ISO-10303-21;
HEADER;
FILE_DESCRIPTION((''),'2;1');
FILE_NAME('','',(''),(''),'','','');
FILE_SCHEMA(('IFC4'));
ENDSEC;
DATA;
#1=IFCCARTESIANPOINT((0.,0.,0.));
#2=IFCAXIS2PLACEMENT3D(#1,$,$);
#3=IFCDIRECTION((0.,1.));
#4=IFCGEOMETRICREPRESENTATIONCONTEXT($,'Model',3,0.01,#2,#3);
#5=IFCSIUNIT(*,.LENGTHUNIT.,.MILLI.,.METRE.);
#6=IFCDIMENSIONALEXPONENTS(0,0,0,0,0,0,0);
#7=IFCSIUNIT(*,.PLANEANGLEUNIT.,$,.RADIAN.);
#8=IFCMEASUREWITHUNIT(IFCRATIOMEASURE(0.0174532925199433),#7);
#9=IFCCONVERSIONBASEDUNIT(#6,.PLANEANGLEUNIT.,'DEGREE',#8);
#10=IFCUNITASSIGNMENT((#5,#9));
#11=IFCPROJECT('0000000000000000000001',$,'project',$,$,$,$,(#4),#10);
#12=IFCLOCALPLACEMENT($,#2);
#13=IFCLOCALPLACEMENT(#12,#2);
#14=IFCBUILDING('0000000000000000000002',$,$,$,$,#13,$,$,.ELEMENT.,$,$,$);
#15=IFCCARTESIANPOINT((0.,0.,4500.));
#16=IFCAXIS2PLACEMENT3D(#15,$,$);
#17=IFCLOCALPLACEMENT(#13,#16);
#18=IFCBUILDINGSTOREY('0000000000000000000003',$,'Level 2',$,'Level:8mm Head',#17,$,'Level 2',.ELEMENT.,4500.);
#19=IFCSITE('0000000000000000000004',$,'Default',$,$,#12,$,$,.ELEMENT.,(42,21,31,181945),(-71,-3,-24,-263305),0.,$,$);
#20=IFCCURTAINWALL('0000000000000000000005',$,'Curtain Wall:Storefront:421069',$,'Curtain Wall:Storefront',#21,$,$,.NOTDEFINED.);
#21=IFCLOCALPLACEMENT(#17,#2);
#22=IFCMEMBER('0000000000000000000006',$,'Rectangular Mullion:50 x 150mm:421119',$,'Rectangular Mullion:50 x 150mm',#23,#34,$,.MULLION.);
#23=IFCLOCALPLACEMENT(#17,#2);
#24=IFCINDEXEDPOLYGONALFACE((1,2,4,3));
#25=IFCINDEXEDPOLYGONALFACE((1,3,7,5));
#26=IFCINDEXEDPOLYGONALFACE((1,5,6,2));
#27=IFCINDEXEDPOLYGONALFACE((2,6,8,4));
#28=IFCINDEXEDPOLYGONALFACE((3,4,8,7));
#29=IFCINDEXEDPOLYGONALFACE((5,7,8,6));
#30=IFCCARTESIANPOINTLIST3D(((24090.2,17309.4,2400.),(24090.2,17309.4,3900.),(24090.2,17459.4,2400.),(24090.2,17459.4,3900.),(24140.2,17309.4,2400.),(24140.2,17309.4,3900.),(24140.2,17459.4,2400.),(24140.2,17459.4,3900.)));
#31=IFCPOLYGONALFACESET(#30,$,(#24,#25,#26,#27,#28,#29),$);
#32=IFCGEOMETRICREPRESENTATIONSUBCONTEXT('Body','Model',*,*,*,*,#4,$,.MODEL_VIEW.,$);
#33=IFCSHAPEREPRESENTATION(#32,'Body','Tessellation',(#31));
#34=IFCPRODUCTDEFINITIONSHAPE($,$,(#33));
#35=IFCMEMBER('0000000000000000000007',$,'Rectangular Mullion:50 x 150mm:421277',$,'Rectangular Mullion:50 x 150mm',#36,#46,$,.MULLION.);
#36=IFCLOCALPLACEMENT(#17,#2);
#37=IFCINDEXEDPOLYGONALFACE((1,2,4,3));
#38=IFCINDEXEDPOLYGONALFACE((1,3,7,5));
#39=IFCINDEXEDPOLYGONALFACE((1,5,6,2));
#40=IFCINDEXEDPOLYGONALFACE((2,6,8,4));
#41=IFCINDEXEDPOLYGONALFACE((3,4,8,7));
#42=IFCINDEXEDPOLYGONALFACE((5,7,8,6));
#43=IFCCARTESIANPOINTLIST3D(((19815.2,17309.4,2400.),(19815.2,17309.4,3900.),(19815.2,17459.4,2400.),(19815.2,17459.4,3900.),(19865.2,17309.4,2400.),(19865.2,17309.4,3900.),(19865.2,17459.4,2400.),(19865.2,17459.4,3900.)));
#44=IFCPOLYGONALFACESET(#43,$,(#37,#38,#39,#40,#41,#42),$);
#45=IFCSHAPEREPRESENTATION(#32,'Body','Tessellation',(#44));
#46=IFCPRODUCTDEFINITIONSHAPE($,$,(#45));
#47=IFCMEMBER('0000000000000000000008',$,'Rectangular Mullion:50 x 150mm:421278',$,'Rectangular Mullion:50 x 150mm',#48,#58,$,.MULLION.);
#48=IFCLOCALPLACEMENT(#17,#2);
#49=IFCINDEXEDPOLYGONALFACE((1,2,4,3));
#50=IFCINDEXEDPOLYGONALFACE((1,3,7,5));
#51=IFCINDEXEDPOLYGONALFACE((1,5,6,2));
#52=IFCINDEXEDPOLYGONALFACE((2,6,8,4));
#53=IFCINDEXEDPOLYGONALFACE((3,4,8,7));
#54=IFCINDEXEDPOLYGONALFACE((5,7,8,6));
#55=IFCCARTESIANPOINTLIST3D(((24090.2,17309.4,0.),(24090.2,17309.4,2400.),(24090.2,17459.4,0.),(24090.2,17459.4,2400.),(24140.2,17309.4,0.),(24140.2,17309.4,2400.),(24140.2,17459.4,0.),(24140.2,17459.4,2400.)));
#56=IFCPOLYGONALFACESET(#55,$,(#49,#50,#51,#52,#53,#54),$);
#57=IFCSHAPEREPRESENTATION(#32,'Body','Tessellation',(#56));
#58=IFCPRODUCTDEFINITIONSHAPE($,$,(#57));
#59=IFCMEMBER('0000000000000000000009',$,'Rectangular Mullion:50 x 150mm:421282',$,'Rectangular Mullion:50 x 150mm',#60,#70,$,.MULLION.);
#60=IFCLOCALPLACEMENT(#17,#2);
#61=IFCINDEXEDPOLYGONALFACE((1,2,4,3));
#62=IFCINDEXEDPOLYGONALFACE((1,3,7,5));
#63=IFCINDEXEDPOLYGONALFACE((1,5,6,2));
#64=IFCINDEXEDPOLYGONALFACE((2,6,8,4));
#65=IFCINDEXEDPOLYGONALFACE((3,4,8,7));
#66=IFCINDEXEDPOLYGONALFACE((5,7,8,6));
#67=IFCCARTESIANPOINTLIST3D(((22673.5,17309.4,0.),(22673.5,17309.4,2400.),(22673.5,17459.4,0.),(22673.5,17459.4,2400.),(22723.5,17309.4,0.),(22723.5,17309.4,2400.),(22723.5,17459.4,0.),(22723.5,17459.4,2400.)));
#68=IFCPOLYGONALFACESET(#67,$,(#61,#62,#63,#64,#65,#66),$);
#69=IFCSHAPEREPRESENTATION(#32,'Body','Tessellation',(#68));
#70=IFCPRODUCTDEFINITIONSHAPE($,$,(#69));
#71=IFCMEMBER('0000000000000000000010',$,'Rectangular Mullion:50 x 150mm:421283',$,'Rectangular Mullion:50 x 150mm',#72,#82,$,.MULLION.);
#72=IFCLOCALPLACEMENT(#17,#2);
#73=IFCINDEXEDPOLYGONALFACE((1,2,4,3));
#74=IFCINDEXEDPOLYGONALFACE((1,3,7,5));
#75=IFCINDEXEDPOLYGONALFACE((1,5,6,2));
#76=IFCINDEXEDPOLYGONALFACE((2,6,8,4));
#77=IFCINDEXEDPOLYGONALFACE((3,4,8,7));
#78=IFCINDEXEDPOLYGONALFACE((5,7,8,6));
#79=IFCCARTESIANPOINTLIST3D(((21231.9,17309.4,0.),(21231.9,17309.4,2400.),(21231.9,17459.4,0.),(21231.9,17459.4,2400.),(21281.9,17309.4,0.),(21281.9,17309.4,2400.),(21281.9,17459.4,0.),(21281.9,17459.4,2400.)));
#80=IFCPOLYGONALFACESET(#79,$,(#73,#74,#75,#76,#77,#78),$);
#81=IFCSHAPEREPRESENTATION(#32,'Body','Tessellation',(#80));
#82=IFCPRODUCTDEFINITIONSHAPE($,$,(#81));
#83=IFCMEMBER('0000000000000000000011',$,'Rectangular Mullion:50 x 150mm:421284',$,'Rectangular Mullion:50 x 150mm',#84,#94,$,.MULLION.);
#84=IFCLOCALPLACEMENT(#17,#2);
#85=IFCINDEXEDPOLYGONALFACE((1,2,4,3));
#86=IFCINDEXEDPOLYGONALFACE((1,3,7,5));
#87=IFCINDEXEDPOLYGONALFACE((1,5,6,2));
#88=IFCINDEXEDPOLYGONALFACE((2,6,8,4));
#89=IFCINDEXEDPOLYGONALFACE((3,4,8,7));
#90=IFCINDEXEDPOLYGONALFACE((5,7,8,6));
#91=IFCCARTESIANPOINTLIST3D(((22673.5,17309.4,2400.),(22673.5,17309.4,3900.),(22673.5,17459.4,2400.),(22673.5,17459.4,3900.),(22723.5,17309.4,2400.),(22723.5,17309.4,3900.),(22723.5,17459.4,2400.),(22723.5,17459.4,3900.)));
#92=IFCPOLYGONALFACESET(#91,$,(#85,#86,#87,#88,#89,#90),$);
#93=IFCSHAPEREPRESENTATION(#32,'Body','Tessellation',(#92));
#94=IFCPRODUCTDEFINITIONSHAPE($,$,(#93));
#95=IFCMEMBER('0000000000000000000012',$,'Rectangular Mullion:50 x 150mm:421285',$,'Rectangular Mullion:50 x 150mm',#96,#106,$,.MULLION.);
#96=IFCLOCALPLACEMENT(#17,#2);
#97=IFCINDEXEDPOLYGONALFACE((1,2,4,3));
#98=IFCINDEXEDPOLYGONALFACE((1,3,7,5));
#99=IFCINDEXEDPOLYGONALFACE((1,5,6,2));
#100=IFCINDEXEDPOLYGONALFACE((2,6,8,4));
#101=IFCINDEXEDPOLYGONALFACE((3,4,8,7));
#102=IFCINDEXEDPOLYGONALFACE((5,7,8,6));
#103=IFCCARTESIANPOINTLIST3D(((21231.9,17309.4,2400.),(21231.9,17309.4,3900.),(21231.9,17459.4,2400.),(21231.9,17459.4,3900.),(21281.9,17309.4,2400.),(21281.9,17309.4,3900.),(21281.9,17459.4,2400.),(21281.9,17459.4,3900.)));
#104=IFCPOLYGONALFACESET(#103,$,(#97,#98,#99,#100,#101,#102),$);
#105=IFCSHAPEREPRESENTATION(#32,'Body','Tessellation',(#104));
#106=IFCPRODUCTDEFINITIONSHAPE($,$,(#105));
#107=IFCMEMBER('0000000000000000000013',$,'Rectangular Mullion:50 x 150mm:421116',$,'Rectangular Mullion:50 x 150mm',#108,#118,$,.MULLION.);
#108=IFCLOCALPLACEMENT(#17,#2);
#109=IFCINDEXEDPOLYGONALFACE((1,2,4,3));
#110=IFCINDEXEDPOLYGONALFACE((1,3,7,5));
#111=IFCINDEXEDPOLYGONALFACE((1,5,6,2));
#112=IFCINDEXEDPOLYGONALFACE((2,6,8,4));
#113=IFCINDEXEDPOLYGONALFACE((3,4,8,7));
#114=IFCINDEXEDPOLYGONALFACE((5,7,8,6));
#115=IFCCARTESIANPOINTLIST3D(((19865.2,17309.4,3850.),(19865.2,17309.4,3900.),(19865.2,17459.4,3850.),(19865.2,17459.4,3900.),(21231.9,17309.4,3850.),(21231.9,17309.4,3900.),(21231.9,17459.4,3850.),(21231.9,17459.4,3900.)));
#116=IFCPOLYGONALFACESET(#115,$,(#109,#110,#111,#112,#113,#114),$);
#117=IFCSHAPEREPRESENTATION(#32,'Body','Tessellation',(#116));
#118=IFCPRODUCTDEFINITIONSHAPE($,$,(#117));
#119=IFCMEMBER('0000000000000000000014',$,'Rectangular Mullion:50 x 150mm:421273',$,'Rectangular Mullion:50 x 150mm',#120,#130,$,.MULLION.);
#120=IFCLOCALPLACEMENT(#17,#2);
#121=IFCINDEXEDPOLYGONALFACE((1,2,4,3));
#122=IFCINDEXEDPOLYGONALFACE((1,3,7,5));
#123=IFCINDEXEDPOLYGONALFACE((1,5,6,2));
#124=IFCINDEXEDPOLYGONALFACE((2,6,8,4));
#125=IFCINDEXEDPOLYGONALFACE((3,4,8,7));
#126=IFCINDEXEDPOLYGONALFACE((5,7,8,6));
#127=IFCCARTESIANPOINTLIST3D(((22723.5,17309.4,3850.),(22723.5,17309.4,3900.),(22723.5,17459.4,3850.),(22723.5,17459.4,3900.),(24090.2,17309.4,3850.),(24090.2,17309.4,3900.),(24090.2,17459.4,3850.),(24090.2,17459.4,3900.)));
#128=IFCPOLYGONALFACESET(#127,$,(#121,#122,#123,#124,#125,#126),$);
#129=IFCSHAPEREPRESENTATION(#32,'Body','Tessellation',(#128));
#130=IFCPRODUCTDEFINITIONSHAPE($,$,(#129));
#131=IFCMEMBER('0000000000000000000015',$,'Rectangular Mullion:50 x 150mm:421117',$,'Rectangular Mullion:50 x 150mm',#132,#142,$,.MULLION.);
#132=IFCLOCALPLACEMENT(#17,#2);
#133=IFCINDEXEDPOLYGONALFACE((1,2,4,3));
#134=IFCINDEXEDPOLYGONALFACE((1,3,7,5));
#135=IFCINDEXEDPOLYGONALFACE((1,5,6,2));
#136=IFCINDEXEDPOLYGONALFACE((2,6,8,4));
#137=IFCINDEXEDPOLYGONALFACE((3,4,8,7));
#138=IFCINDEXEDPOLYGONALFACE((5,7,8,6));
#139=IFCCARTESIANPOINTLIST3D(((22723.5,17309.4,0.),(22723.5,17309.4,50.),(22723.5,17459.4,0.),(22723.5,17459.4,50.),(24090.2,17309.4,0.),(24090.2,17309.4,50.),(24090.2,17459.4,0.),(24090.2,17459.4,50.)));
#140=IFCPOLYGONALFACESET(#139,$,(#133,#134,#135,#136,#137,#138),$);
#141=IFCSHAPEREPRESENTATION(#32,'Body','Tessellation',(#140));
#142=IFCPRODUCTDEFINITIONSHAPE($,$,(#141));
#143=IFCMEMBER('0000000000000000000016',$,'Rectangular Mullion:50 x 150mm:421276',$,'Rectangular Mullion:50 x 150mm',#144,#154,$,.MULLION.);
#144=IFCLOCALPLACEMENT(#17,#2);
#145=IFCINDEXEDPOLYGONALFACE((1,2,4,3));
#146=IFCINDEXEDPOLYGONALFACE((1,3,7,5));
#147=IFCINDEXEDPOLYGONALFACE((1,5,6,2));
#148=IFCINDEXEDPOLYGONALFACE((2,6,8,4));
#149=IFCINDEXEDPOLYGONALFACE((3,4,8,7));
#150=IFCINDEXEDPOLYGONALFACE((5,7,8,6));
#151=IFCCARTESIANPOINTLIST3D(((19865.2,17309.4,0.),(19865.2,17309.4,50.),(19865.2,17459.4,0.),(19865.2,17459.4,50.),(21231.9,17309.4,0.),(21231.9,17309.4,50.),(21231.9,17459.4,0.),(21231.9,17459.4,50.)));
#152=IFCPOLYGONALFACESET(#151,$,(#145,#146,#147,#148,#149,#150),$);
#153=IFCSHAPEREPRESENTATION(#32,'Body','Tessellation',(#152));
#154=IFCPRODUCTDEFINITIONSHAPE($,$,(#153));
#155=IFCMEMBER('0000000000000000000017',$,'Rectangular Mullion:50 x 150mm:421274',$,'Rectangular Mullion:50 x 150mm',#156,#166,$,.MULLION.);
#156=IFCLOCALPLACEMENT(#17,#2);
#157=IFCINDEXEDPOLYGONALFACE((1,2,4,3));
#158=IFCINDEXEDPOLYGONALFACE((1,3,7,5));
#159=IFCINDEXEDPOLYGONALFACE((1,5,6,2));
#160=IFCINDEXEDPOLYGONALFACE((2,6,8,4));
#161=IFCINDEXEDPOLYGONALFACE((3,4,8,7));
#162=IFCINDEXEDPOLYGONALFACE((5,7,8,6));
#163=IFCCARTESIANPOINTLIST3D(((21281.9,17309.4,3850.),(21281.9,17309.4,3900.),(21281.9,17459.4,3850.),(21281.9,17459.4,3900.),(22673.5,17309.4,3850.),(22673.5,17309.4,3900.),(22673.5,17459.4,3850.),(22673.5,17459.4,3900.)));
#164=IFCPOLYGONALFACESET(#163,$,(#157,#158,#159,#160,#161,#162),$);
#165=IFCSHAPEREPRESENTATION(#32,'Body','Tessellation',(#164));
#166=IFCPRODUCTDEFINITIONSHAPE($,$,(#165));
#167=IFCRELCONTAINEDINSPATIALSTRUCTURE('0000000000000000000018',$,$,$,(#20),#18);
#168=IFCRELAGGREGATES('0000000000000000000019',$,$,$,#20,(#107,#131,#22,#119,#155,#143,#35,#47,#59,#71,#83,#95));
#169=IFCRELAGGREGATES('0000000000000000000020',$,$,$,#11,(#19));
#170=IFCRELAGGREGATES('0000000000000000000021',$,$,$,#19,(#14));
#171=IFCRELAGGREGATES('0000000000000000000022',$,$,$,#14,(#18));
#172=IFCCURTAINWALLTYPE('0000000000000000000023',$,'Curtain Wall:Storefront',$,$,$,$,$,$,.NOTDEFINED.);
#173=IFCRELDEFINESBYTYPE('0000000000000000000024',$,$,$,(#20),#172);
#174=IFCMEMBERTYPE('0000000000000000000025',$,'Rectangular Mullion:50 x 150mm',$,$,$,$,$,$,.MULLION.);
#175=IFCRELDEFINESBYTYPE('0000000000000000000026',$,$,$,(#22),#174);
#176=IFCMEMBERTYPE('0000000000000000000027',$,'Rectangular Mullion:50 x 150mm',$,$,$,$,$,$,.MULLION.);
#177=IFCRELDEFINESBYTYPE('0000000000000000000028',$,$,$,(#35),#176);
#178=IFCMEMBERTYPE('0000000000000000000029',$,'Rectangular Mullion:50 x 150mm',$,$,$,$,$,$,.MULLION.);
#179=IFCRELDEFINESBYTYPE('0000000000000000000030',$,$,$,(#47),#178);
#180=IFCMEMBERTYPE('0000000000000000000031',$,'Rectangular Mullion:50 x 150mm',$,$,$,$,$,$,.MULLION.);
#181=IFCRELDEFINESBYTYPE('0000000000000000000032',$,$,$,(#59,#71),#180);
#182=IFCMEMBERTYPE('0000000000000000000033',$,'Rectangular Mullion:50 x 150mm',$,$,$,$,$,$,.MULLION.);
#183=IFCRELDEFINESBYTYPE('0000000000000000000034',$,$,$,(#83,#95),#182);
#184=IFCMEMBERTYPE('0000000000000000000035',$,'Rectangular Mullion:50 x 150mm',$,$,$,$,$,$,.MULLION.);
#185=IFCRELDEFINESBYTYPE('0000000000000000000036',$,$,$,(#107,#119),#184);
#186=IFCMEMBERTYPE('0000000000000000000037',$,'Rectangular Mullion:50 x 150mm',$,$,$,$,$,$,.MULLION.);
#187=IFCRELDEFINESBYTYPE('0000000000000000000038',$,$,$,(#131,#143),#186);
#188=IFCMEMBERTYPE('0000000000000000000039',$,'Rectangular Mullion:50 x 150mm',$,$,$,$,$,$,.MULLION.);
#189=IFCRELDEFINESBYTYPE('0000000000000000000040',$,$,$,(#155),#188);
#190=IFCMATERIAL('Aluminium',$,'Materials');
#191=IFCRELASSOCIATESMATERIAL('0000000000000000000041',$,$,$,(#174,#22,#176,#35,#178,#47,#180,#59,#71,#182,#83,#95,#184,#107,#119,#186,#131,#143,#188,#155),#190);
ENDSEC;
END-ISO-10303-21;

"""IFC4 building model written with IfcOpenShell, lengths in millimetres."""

from ifc_helpers import new_model, entity, si_unit, converted_unit, direction, frame, origin, place, context, subcontext, project, spatial, indexed_curve, outline, extrude, source, transform, mapped, material, type_object, type_shapes, element, aggregate, save


model = new_model("IFC4")

# Units and contexts
model_context = context("Model", 3, precision=0.01, world=origin(), true_north=direction((0.0, 1.0)))
body_context = subcontext(model_context, "Body", "Model", "MODEL_VIEW")
ifc_project = project(units=[si_unit("LENGTHUNIT", "METRE", prefix="MILLI"), converted_unit("PLANEANGLEUNIT", "DEGREE", entity("IfcRatioMeasure", 0.0174532925199433), si_unit("PLANEANGLEUNIT", "RADIAN"), dimensions=[0, 0, 0, 0, 0, 0, 0])], contexts=[model_context])

# Site, building, storey
site_placement = place(None, origin())
site = spatial("IfcSite", under=ifc_project, at=site_placement, Name="Default", CompositionType="ELEMENT", RefLatitude=(42, 21, 31, 181945), RefLongitude=(-71, -3, -24, -263305), RefElevation=0.0)
building_placement = place(site_placement, origin())
building = spatial("IfcBuilding", under=site, at=building_placement, CompositionType="ELEMENT")
storey_placement = place(building_placement, frame((0.0, 0.0, 4500.0)))
storey = spatial("IfcBuildingStorey", under=building, at=storey_placement, Name="Level 2", ObjectType="Level:8mm Head", LongName="Level 2", CompositionType="ELEMENT", Elevation=4500.0)

# Curtain wall, members
curtain_wall_type_1 = type_object("IfcCurtainWallType", Name="Curtain Wall:Storefront", PredefinedType="NOTDEFINED")
curtain_wall_1_placement = place(storey_placement, frame((0.0, 0.0, -4500.0)))
curtain_wall_1 = element("IfcCurtainWall", 1, at=curtain_wall_1_placement, inside=storey, type_object=curtain_wall_type_1, Name="Curtain Wall:Storefront:421069", ObjectType="Curtain Wall:Storefront", PredefinedType="NOTDEFINED")
ifc_material_1 = material(Name="Aluminium", Category="Materials")
member_type_1 = type_object("IfcMemberType", Name="Rectangular Mullion:50 x 150mm", PredefinedType="MULLION", material=ifc_material_1)
shared_shape_1 = source(origin(), body_context, "Body", "SweptSolid", [
    extrude(outline(indexed_curve([(-75.0, -25.0), (75.0, -25.0), (75.0, 25.0), (-75.0, 25.0), (-75.0, -25.0)], self_intersect=False)), frame((-25.0, 0.0, -1500.0), z_axis=(0.0, 0.0, 1.0), x_axis=(0.0, -1.0, 0.0)), (0.0, 0.0, 1.0), 1500.0),
])
type_shapes(member_type_1, [shared_shape_1])
member_1_placement = place(storey_placement, frame((24140.2, 17384.4, 3900.0)))
member_1 = element("IfcMember", 2, at=member_1_placement, type_object=member_type_1, material=ifc_material_1, Name="Rectangular Mullion:50 x 150mm:421119", ObjectType="Rectangular Mullion:50 x 150mm", PredefinedType="MULLION", context=body_context, shape_type="MappedRepresentation", body=[
    mapped(shared_shape_1, transform((0.0, 0.0, 0.0), scale=1.0)),
])
member_type_2 = type_object("IfcMemberType", Name="Rectangular Mullion:50 x 150mm", PredefinedType="MULLION", material=ifc_material_1)
shared_shape_2 = source(origin(), body_context, "Body", "SweptSolid", [
    extrude(outline(indexed_curve([(-75.0, -25.0), (75.0, -25.0), (75.0, 25.0), (-75.0, 25.0), (-75.0, -25.0)], self_intersect=False)), frame((-25.0, 0.0, -1500.0), z_axis=(0.0, 0.0, 1.0), x_axis=(0.0, -1.0, 0.0)), (0.0, 0.0, 1.0), 1500.0),
])
type_shapes(member_type_2, [shared_shape_2])
member_2_placement = place(storey_placement, frame((19815.2, 17384.4, 2400.0), z_axis=(0.0, 0.0, -1.0), x_axis=(-1.0, 0.0, 0.0)))
member_2 = element("IfcMember", 3, at=member_2_placement, type_object=member_type_2, material=ifc_material_1, Name="Rectangular Mullion:50 x 150mm:421277", ObjectType="Rectangular Mullion:50 x 150mm", PredefinedType="MULLION", context=body_context, shape_type="MappedRepresentation", body=[
    mapped(shared_shape_2, transform((0.0, 0.0, 0.0), scale=1.0)),
])
member_type_3 = type_object("IfcMemberType", Name="Rectangular Mullion:50 x 150mm", PredefinedType="MULLION", material=ifc_material_1)
shared_shape_3 = source(origin(), body_context, "Body", "SweptSolid", [
    extrude(outline(indexed_curve([(-75.0, -25.0), (75.0, -25.0), (75.0, 25.0), (-75.0, 25.0), (-75.0, -25.0)], self_intersect=False)), frame((-25.0, 0.0, -2400.0), z_axis=(0.0, 0.0, 1.0), x_axis=(0.0, -1.0, 0.0)), (0.0, 0.0, 1.0), 2400.0),
])
type_shapes(member_type_3, [shared_shape_3])
member_3_placement = place(storey_placement, frame((24140.2, 17384.4, 2400.0)))
member_3 = element("IfcMember", 4, at=member_3_placement, type_object=member_type_3, material=ifc_material_1, Name="Rectangular Mullion:50 x 150mm:421278", ObjectType="Rectangular Mullion:50 x 150mm", PredefinedType="MULLION", context=body_context, shape_type="MappedRepresentation", body=[
    mapped(shared_shape_3, transform((0.0, 0.0, 0.0), scale=1.0)),
])
member_type_4 = type_object("IfcMemberType", Name="Rectangular Mullion:50 x 150mm", PredefinedType="MULLION", material=ifc_material_1)
shared_shape_4 = source(origin(), body_context, "Body", "SweptSolid", [
    extrude(outline(indexed_curve([(-75.0, -25.0), (75.0, -25.0), (75.0, 25.0), (-75.0, 25.0), (-75.0, -25.0)], self_intersect=False)), frame((0.0, 0.0, -2400.0), z_axis=(0.0, 0.0, 1.0), x_axis=(0.0, -1.0, 0.0)), (0.0, 0.0, 1.0), 2400.0),
])
type_shapes(member_type_4, [shared_shape_4])
member_4_placement = place(storey_placement, frame((22698.5, 17384.4, 0.0), z_axis=(0.0, 0.0, -1.0), x_axis=(-1.0, 0.0, 0.0)))
member_4 = element("IfcMember", 5, at=member_4_placement, type_object=member_type_4, material=ifc_material_1, Name="Rectangular Mullion:50 x 150mm:421282", ObjectType="Rectangular Mullion:50 x 150mm", PredefinedType="MULLION", context=body_context, shape_type="MappedRepresentation", body=[
    mapped(shared_shape_4, transform((0.0, 0.0, 0.0), scale=1.0)),
])
member_5_placement = place(storey_placement, frame((21256.9, 17384.4, 0.0), z_axis=(0.0, 0.0, -1.0), x_axis=(-1.0, 0.0, 0.0)))
member_5 = element("IfcMember", 6, at=member_5_placement, type_object=member_type_4, material=ifc_material_1, Name="Rectangular Mullion:50 x 150mm:421283", ObjectType="Rectangular Mullion:50 x 150mm", PredefinedType="MULLION", context=body_context, shape_type="MappedRepresentation", body=[
    mapped(shared_shape_4, transform((0.0, 0.0, 0.0), scale=1.0)),
])
member_type_5 = type_object("IfcMemberType", Name="Rectangular Mullion:50 x 150mm", PredefinedType="MULLION", material=ifc_material_1)
shared_shape_5 = source(origin(), body_context, "Body", "SweptSolid", [
    extrude(outline(indexed_curve([(-75.0, -25.0), (75.0, -25.0), (75.0, 25.0), (-75.0, 25.0), (-75.0, -25.0)], self_intersect=False)), frame((0.0, 0.0, -1500.0), z_axis=(0.0, 0.0, 1.0), x_axis=(0.0, -1.0, 0.0)), (0.0, 0.0, 1.0), 1500.0),
])
type_shapes(member_type_5, [shared_shape_5])
member_6_placement = place(storey_placement, frame((22698.5, 17384.4, 2400.0), z_axis=(0.0, 0.0, -1.0), x_axis=(-1.0, 0.0, 0.0)))
member_6 = element("IfcMember", 7, at=member_6_placement, type_object=member_type_5, material=ifc_material_1, Name="Rectangular Mullion:50 x 150mm:421284", ObjectType="Rectangular Mullion:50 x 150mm", PredefinedType="MULLION", context=body_context, shape_type="MappedRepresentation", body=[
    mapped(shared_shape_5, transform((0.0, 0.0, 0.0), scale=1.0)),
])
member_7_placement = place(storey_placement, frame((21256.9, 17384.4, 2400.0), z_axis=(0.0, 0.0, -1.0), x_axis=(-1.0, 0.0, 0.0)))
member_7 = element("IfcMember", 8, at=member_7_placement, type_object=member_type_5, material=ifc_material_1, Name="Rectangular Mullion:50 x 150mm:421285", ObjectType="Rectangular Mullion:50 x 150mm", PredefinedType="MULLION", context=body_context, shape_type="MappedRepresentation", body=[
    mapped(shared_shape_5, transform((0.0, 0.0, 0.0), scale=1.0)),
])
member_type_6 = type_object("IfcMemberType", Name="Rectangular Mullion:50 x 150mm", PredefinedType="MULLION", material=ifc_material_1)
shared_shape_6 = source(origin(), body_context, "Body", "SweptSolid", [
    extrude(outline(indexed_curve([(-75.0, -25.0), (75.0, -25.0), (75.0, 25.0), (-75.0, 25.0), (-75.0, -25.0)], self_intersect=False)), frame((-25.0, 0.0, -1366.7), z_axis=(0.0, 0.0, 1.0), x_axis=(0.0, -1.0, 0.0)), (0.0, 0.0, 1.0), 1366.7),
])
type_shapes(member_type_6, [shared_shape_6])
member_8_placement = place(storey_placement, frame((19865.2, 17384.4, 3900.0), z_axis=(-1.0, 0.0, 0.0), x_axis=(0.0, 0.0, 1.0)))
member_8 = element("IfcMember", 9, at=member_8_placement, type_object=member_type_6, material=ifc_material_1, Name="Rectangular Mullion:50 x 150mm:421116", ObjectType="Rectangular Mullion:50 x 150mm", PredefinedType="MULLION", context=body_context, shape_type="MappedRepresentation", body=[
    mapped(shared_shape_6, transform((0.0, 0.0, 0.0), scale=1.0)),
])
member_9_placement = place(storey_placement, frame((22723.5, 17384.4, 3900.0), z_axis=(-1.0, 0.0, 0.0), x_axis=(0.0, 0.0, 1.0)))
member_9 = element("IfcMember", 10, at=member_9_placement, type_object=member_type_6, material=ifc_material_1, Name="Rectangular Mullion:50 x 150mm:421273", ObjectType="Rectangular Mullion:50 x 150mm", PredefinedType="MULLION", context=body_context, shape_type="MappedRepresentation", body=[
    mapped(shared_shape_6, transform((0.0, 0.0, 0.0), scale=1.0)),
])
member_type_7 = type_object("IfcMemberType", Name="Rectangular Mullion:50 x 150mm", PredefinedType="MULLION", material=ifc_material_1)
shared_shape_7 = source(origin(), body_context, "Body", "SweptSolid", [
    extrude(outline(indexed_curve([(-75.0, -25.0), (75.0, -25.0), (75.0, 25.0), (-75.0, 25.0), (-75.0, -25.0)], self_intersect=False)), frame((-25.0, 0.0, -1366.7), z_axis=(0.0, 0.0, 1.0), x_axis=(0.0, -1.0, 0.0)), (0.0, 0.0, 1.0), 1366.7),
])
type_shapes(member_type_7, [shared_shape_7])
member_10_placement = place(storey_placement, frame((24090.2, 17384.4, 0.0), z_axis=(1.0, 0.0, 0.0), x_axis=(0.0, 0.0, -1.0)))
member_10 = element("IfcMember", 11, at=member_10_placement, type_object=member_type_7, material=ifc_material_1, Name="Rectangular Mullion:50 x 150mm:421117", ObjectType="Rectangular Mullion:50 x 150mm", PredefinedType="MULLION", context=body_context, shape_type="MappedRepresentation", body=[
    mapped(shared_shape_7, transform((0.0, 0.0, 0.0), scale=1.0)),
])
member_11_placement = place(storey_placement, frame((21231.9, 17384.4, 0.0), z_axis=(1.0, 0.0, 0.0), x_axis=(0.0, 0.0, -1.0)))
member_11 = element("IfcMember", 12, at=member_11_placement, type_object=member_type_7, material=ifc_material_1, Name="Rectangular Mullion:50 x 150mm:421276", ObjectType="Rectangular Mullion:50 x 150mm", PredefinedType="MULLION", context=body_context, shape_type="MappedRepresentation", body=[
    mapped(shared_shape_7, transform((0.0, 0.0, 0.0), scale=1.0)),
])
member_type_8 = type_object("IfcMemberType", Name="Rectangular Mullion:50 x 150mm", PredefinedType="MULLION", material=ifc_material_1)
shared_shape_8 = source(origin(), body_context, "Body", "SweptSolid", [
    extrude(outline(indexed_curve([(-75.0, -25.0), (75.0, -25.0), (75.0, 25.0), (-75.0, 25.0), (-75.0, -25.0)], self_intersect=False)), frame((-25.0, 0.0, -1391.7), z_axis=(0.0, 0.0, 1.0), x_axis=(0.0, -1.0, 0.0)), (0.0, 0.0, 1.0), 1391.7),
])
type_shapes(member_type_8, [shared_shape_8])
member_12_placement = place(storey_placement, frame((21281.9, 17384.4, 3900.0), z_axis=(-1.0, 0.0, 0.0), x_axis=(0.0, 0.0, 1.0)))
member_12 = element("IfcMember", 13, at=member_12_placement, type_object=member_type_8, material=ifc_material_1, Name="Rectangular Mullion:50 x 150mm:421274", ObjectType="Rectangular Mullion:50 x 150mm", PredefinedType="MULLION", context=body_context, shape_type="MappedRepresentation", body=[
    mapped(shared_shape_8, transform((0.0, 0.0, 0.0), scale=1.0)),
])

aggregate(curtain_wall_1, [member_8, member_10, member_1, member_9, member_12, member_11, member_2, member_3, member_4, member_5, member_6, member_7])

save(model, "model.ifc")
